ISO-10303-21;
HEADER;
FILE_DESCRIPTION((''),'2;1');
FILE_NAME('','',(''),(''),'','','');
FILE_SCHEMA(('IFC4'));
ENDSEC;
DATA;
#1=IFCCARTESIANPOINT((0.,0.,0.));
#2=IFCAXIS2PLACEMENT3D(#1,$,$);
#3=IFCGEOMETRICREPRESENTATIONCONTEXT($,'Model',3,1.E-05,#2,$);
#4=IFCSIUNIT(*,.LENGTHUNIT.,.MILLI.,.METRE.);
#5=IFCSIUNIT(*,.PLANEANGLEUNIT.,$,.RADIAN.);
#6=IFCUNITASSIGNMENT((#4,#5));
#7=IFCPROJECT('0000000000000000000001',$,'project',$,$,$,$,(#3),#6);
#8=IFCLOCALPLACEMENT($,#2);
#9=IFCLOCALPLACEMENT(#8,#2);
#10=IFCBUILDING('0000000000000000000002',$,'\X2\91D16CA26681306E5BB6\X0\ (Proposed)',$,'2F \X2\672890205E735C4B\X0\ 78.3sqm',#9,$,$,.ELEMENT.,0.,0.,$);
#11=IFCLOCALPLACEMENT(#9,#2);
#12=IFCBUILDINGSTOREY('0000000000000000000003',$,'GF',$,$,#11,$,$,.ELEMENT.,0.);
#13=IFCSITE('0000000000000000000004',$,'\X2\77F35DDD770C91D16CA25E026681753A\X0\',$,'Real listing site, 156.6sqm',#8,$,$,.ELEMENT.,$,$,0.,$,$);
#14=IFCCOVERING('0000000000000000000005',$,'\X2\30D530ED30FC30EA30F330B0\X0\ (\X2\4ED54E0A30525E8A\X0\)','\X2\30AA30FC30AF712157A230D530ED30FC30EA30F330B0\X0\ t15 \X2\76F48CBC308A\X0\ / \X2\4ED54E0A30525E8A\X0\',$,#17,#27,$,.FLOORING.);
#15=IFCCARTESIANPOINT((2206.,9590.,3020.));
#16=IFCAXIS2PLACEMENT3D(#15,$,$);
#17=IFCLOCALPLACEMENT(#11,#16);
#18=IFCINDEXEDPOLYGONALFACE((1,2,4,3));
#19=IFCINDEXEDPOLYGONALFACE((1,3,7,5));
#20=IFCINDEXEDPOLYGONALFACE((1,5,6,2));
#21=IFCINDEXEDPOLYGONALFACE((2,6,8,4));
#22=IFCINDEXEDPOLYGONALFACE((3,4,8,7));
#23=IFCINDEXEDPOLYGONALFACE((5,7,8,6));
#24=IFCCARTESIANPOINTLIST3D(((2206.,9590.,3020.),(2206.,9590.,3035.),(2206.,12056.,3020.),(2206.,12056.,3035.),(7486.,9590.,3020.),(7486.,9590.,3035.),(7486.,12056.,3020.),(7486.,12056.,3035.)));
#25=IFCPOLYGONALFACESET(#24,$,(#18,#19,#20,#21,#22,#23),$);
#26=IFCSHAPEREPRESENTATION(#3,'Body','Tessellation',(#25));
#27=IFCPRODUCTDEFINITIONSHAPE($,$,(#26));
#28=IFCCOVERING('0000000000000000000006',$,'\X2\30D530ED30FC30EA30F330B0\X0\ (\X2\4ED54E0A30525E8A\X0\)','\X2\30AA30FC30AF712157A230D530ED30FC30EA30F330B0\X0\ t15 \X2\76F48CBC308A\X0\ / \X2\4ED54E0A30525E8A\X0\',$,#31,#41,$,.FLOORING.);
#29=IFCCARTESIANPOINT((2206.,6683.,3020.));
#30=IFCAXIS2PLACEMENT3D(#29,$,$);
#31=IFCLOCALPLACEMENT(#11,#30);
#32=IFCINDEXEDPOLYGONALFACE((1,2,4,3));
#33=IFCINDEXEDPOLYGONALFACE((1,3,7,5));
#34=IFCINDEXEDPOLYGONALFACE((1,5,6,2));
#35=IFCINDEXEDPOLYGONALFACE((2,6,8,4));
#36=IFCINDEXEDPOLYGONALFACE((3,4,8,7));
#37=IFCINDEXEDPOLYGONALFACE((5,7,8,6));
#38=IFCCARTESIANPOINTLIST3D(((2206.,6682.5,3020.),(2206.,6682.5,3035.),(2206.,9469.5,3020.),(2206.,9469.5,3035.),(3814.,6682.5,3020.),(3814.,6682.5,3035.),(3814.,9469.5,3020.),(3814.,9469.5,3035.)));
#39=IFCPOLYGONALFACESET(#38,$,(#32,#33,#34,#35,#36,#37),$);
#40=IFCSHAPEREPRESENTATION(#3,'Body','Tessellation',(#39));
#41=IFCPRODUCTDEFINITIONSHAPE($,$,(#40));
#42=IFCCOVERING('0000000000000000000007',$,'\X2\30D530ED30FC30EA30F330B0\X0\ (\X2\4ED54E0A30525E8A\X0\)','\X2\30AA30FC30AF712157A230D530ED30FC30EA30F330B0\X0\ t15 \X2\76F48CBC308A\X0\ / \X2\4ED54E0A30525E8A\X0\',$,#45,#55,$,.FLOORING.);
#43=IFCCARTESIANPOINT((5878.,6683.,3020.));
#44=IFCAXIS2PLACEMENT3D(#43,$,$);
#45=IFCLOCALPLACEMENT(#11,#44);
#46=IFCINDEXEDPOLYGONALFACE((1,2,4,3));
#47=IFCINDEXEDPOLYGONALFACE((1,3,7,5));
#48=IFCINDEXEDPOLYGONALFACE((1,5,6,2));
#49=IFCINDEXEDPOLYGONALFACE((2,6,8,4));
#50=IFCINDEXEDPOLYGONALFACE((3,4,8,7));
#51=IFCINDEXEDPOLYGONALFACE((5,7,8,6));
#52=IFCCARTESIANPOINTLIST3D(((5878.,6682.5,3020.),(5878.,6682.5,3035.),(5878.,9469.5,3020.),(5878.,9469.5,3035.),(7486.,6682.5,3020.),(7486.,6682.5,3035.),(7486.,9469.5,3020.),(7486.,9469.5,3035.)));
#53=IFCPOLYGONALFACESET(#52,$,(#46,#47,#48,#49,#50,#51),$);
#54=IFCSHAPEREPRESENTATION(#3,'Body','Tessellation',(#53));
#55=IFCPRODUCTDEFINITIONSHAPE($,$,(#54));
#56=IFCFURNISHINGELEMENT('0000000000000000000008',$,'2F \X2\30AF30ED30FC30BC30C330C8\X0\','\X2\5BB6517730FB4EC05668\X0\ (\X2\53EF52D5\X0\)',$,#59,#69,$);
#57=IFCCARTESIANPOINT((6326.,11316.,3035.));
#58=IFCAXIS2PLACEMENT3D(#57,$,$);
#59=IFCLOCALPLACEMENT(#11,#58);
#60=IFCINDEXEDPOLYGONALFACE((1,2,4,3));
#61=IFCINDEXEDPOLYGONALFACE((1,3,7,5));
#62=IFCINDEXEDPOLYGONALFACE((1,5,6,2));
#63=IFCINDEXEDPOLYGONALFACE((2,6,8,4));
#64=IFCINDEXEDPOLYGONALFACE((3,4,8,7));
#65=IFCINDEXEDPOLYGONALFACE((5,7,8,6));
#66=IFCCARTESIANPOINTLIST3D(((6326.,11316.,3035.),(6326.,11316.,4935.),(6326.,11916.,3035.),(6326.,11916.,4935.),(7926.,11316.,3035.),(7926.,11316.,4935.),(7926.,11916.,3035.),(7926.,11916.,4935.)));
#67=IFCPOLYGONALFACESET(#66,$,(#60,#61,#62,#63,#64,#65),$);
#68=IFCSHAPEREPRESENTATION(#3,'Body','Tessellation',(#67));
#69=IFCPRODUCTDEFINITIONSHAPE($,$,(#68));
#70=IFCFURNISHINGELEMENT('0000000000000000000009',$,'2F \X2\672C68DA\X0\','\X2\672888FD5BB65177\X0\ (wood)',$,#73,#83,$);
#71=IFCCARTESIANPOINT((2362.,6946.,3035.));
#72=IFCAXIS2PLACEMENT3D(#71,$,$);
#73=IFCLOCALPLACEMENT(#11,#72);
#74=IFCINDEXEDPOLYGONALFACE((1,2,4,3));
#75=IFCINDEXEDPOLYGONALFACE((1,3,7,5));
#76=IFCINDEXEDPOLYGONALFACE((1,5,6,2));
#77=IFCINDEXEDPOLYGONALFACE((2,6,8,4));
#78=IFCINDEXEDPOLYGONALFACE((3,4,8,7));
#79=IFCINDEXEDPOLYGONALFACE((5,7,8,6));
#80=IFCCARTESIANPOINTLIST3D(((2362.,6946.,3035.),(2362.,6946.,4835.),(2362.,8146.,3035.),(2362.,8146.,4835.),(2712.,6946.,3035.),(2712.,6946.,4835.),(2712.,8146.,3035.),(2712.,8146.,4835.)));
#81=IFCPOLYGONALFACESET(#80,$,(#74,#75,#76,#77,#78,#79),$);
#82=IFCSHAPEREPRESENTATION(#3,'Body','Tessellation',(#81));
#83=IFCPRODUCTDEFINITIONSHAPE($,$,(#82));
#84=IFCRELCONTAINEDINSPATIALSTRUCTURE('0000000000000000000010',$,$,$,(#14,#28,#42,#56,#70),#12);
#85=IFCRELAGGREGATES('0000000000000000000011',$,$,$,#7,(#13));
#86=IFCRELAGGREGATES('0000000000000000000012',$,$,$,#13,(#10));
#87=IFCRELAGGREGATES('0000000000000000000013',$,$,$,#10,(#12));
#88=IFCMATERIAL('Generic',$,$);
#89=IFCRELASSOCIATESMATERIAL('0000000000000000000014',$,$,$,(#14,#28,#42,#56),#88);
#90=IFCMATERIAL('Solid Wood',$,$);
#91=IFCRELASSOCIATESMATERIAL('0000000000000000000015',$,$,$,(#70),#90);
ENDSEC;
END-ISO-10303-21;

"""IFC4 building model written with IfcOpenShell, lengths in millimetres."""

from ifc_helpers import new_model, si_unit, frame, frame_2d, origin, place, context, project, spatial, rectangle, extrude, material, element, save


model = new_model("IFC4")

# Units and contexts
model_context = context("Model", 3, precision=1e-05, world=origin())
ifc_project = project(units=[si_unit("LENGTHUNIT", "METRE", prefix="MILLI"), si_unit("PLANEANGLEUNIT", "RADIAN")], contexts=[model_context])

# Site, building, storey
site_placement = place(None, origin())
site = spatial("IfcSite", under=ifc_project, at=site_placement, Name="石川県金沢市暁町", ObjectType="Real listing site, 156.6sqm", CompositionType="ELEMENT", RefElevation=0.0)
building_placement = place(site_placement, origin())
building = spatial("IfcBuilding", under=site, at=building_placement, Name="金沢暁の家 (Proposed)", ObjectType="2F 木造平屋 78.3sqm", CompositionType="ELEMENT", ElevationOfRefHeight=0.0, ElevationOfTerrain=0.0)
storey_placement = place(building_placement, origin())
storey = spatial("IfcBuildingStorey", under=building, at=storey_placement, Name="GF", CompositionType="ELEMENT", Elevation=0.0)

# Shared definitions
ifc_material_1 = material(Name="Solid Wood")

# Coverings
ifc_material_2 = material(Name="Generic")
covering_1_placement = place(storey_placement, frame((2206.0, 9590.0, 3020.0)))
element("IfcCovering", 1, at=covering_1_placement, inside=storey, material=ifc_material_2, Name="フローリング (仕上げ床)", Description="オーク無垢フローリング t15 直貼り / 仕上げ床", PredefinedType="FLOORING", context=model_context, shape_type="SweptSolid", body=[
    extrude(rectangle(XDim=5280.0, YDim=2466.0, at=frame_2d((2640.0, 1233.0))), frame((2206.0, 9590.0, 3020.0)), (0.0, 0.0, 1.0), 15.0),
])
covering_2_placement = place(storey_placement, frame((2206.0, 6683.0, 3020.0)))
element("IfcCovering", 2, at=covering_2_placement, inside=storey, material=ifc_material_2, Name="フローリング (仕上げ床)", Description="オーク無垢フローリング t15 直貼り / 仕上げ床", PredefinedType="FLOORING", context=model_context, shape_type="SweptSolid", body=[
    extrude(rectangle(XDim=1608.0, YDim=2787.0, at=frame_2d((804.0, 1393.0))), frame((2206.0, 6683.0, 3020.0)), (0.0, 0.0, 1.0), 15.0),
])
covering_3_placement = place(storey_placement, frame((5878.0, 6683.0, 3020.0)))
element("IfcCovering", 3, at=covering_3_placement, inside=storey, material=ifc_material_2, Name="フローリング (仕上げ床)", Description="オーク無垢フローリング t15 直貼り / 仕上げ床", PredefinedType="FLOORING", context=model_context, shape_type="SweptSolid", body=[
    extrude(rectangle(XDim=1608.0, YDim=2787.0, at=frame_2d((804.0, 1393.0))), frame((5878.0, 6683.0, 3020.0)), (0.0, 0.0, 1.0), 15.0),
])

# Furnishing elements
furnishing_1_placement = place(storey_placement, frame((6326.0, 11316.0, 3035.0)))
element("IfcFurnishingElement", 4, at=furnishing_1_placement, inside=storey, material=ifc_material_2, Name="2F クローゼット", Description="家具・什器 (可動)", context=model_context, shape_type="SweptSolid", body=[
    extrude(rectangle(XDim=1600.0, YDim=600.0, at=frame_2d((800.0, 300.0))), frame((6326.0, 11316.0, 3035.0)), (0.0, 0.0, 1.0), 1900.0),
])
furnishing_2_placement = place(storey_placement, frame((2362.0, 6946.0, 3035.0)))
element("IfcFurnishingElement", 5, at=furnishing_2_placement, inside=storey, material=ifc_material_1, Name="2F 本棚", Description="木製家具 (wood)", context=model_context, shape_type="SweptSolid", body=[
    extrude(rectangle(XDim=350.0, YDim=1200.0, at=frame_2d((175.0, 600.0))), frame((2362.0, 6946.0, 3035.0)), (0.0, 0.0, 1.0), 1800.0),
])

save(model, "model.ifc")
